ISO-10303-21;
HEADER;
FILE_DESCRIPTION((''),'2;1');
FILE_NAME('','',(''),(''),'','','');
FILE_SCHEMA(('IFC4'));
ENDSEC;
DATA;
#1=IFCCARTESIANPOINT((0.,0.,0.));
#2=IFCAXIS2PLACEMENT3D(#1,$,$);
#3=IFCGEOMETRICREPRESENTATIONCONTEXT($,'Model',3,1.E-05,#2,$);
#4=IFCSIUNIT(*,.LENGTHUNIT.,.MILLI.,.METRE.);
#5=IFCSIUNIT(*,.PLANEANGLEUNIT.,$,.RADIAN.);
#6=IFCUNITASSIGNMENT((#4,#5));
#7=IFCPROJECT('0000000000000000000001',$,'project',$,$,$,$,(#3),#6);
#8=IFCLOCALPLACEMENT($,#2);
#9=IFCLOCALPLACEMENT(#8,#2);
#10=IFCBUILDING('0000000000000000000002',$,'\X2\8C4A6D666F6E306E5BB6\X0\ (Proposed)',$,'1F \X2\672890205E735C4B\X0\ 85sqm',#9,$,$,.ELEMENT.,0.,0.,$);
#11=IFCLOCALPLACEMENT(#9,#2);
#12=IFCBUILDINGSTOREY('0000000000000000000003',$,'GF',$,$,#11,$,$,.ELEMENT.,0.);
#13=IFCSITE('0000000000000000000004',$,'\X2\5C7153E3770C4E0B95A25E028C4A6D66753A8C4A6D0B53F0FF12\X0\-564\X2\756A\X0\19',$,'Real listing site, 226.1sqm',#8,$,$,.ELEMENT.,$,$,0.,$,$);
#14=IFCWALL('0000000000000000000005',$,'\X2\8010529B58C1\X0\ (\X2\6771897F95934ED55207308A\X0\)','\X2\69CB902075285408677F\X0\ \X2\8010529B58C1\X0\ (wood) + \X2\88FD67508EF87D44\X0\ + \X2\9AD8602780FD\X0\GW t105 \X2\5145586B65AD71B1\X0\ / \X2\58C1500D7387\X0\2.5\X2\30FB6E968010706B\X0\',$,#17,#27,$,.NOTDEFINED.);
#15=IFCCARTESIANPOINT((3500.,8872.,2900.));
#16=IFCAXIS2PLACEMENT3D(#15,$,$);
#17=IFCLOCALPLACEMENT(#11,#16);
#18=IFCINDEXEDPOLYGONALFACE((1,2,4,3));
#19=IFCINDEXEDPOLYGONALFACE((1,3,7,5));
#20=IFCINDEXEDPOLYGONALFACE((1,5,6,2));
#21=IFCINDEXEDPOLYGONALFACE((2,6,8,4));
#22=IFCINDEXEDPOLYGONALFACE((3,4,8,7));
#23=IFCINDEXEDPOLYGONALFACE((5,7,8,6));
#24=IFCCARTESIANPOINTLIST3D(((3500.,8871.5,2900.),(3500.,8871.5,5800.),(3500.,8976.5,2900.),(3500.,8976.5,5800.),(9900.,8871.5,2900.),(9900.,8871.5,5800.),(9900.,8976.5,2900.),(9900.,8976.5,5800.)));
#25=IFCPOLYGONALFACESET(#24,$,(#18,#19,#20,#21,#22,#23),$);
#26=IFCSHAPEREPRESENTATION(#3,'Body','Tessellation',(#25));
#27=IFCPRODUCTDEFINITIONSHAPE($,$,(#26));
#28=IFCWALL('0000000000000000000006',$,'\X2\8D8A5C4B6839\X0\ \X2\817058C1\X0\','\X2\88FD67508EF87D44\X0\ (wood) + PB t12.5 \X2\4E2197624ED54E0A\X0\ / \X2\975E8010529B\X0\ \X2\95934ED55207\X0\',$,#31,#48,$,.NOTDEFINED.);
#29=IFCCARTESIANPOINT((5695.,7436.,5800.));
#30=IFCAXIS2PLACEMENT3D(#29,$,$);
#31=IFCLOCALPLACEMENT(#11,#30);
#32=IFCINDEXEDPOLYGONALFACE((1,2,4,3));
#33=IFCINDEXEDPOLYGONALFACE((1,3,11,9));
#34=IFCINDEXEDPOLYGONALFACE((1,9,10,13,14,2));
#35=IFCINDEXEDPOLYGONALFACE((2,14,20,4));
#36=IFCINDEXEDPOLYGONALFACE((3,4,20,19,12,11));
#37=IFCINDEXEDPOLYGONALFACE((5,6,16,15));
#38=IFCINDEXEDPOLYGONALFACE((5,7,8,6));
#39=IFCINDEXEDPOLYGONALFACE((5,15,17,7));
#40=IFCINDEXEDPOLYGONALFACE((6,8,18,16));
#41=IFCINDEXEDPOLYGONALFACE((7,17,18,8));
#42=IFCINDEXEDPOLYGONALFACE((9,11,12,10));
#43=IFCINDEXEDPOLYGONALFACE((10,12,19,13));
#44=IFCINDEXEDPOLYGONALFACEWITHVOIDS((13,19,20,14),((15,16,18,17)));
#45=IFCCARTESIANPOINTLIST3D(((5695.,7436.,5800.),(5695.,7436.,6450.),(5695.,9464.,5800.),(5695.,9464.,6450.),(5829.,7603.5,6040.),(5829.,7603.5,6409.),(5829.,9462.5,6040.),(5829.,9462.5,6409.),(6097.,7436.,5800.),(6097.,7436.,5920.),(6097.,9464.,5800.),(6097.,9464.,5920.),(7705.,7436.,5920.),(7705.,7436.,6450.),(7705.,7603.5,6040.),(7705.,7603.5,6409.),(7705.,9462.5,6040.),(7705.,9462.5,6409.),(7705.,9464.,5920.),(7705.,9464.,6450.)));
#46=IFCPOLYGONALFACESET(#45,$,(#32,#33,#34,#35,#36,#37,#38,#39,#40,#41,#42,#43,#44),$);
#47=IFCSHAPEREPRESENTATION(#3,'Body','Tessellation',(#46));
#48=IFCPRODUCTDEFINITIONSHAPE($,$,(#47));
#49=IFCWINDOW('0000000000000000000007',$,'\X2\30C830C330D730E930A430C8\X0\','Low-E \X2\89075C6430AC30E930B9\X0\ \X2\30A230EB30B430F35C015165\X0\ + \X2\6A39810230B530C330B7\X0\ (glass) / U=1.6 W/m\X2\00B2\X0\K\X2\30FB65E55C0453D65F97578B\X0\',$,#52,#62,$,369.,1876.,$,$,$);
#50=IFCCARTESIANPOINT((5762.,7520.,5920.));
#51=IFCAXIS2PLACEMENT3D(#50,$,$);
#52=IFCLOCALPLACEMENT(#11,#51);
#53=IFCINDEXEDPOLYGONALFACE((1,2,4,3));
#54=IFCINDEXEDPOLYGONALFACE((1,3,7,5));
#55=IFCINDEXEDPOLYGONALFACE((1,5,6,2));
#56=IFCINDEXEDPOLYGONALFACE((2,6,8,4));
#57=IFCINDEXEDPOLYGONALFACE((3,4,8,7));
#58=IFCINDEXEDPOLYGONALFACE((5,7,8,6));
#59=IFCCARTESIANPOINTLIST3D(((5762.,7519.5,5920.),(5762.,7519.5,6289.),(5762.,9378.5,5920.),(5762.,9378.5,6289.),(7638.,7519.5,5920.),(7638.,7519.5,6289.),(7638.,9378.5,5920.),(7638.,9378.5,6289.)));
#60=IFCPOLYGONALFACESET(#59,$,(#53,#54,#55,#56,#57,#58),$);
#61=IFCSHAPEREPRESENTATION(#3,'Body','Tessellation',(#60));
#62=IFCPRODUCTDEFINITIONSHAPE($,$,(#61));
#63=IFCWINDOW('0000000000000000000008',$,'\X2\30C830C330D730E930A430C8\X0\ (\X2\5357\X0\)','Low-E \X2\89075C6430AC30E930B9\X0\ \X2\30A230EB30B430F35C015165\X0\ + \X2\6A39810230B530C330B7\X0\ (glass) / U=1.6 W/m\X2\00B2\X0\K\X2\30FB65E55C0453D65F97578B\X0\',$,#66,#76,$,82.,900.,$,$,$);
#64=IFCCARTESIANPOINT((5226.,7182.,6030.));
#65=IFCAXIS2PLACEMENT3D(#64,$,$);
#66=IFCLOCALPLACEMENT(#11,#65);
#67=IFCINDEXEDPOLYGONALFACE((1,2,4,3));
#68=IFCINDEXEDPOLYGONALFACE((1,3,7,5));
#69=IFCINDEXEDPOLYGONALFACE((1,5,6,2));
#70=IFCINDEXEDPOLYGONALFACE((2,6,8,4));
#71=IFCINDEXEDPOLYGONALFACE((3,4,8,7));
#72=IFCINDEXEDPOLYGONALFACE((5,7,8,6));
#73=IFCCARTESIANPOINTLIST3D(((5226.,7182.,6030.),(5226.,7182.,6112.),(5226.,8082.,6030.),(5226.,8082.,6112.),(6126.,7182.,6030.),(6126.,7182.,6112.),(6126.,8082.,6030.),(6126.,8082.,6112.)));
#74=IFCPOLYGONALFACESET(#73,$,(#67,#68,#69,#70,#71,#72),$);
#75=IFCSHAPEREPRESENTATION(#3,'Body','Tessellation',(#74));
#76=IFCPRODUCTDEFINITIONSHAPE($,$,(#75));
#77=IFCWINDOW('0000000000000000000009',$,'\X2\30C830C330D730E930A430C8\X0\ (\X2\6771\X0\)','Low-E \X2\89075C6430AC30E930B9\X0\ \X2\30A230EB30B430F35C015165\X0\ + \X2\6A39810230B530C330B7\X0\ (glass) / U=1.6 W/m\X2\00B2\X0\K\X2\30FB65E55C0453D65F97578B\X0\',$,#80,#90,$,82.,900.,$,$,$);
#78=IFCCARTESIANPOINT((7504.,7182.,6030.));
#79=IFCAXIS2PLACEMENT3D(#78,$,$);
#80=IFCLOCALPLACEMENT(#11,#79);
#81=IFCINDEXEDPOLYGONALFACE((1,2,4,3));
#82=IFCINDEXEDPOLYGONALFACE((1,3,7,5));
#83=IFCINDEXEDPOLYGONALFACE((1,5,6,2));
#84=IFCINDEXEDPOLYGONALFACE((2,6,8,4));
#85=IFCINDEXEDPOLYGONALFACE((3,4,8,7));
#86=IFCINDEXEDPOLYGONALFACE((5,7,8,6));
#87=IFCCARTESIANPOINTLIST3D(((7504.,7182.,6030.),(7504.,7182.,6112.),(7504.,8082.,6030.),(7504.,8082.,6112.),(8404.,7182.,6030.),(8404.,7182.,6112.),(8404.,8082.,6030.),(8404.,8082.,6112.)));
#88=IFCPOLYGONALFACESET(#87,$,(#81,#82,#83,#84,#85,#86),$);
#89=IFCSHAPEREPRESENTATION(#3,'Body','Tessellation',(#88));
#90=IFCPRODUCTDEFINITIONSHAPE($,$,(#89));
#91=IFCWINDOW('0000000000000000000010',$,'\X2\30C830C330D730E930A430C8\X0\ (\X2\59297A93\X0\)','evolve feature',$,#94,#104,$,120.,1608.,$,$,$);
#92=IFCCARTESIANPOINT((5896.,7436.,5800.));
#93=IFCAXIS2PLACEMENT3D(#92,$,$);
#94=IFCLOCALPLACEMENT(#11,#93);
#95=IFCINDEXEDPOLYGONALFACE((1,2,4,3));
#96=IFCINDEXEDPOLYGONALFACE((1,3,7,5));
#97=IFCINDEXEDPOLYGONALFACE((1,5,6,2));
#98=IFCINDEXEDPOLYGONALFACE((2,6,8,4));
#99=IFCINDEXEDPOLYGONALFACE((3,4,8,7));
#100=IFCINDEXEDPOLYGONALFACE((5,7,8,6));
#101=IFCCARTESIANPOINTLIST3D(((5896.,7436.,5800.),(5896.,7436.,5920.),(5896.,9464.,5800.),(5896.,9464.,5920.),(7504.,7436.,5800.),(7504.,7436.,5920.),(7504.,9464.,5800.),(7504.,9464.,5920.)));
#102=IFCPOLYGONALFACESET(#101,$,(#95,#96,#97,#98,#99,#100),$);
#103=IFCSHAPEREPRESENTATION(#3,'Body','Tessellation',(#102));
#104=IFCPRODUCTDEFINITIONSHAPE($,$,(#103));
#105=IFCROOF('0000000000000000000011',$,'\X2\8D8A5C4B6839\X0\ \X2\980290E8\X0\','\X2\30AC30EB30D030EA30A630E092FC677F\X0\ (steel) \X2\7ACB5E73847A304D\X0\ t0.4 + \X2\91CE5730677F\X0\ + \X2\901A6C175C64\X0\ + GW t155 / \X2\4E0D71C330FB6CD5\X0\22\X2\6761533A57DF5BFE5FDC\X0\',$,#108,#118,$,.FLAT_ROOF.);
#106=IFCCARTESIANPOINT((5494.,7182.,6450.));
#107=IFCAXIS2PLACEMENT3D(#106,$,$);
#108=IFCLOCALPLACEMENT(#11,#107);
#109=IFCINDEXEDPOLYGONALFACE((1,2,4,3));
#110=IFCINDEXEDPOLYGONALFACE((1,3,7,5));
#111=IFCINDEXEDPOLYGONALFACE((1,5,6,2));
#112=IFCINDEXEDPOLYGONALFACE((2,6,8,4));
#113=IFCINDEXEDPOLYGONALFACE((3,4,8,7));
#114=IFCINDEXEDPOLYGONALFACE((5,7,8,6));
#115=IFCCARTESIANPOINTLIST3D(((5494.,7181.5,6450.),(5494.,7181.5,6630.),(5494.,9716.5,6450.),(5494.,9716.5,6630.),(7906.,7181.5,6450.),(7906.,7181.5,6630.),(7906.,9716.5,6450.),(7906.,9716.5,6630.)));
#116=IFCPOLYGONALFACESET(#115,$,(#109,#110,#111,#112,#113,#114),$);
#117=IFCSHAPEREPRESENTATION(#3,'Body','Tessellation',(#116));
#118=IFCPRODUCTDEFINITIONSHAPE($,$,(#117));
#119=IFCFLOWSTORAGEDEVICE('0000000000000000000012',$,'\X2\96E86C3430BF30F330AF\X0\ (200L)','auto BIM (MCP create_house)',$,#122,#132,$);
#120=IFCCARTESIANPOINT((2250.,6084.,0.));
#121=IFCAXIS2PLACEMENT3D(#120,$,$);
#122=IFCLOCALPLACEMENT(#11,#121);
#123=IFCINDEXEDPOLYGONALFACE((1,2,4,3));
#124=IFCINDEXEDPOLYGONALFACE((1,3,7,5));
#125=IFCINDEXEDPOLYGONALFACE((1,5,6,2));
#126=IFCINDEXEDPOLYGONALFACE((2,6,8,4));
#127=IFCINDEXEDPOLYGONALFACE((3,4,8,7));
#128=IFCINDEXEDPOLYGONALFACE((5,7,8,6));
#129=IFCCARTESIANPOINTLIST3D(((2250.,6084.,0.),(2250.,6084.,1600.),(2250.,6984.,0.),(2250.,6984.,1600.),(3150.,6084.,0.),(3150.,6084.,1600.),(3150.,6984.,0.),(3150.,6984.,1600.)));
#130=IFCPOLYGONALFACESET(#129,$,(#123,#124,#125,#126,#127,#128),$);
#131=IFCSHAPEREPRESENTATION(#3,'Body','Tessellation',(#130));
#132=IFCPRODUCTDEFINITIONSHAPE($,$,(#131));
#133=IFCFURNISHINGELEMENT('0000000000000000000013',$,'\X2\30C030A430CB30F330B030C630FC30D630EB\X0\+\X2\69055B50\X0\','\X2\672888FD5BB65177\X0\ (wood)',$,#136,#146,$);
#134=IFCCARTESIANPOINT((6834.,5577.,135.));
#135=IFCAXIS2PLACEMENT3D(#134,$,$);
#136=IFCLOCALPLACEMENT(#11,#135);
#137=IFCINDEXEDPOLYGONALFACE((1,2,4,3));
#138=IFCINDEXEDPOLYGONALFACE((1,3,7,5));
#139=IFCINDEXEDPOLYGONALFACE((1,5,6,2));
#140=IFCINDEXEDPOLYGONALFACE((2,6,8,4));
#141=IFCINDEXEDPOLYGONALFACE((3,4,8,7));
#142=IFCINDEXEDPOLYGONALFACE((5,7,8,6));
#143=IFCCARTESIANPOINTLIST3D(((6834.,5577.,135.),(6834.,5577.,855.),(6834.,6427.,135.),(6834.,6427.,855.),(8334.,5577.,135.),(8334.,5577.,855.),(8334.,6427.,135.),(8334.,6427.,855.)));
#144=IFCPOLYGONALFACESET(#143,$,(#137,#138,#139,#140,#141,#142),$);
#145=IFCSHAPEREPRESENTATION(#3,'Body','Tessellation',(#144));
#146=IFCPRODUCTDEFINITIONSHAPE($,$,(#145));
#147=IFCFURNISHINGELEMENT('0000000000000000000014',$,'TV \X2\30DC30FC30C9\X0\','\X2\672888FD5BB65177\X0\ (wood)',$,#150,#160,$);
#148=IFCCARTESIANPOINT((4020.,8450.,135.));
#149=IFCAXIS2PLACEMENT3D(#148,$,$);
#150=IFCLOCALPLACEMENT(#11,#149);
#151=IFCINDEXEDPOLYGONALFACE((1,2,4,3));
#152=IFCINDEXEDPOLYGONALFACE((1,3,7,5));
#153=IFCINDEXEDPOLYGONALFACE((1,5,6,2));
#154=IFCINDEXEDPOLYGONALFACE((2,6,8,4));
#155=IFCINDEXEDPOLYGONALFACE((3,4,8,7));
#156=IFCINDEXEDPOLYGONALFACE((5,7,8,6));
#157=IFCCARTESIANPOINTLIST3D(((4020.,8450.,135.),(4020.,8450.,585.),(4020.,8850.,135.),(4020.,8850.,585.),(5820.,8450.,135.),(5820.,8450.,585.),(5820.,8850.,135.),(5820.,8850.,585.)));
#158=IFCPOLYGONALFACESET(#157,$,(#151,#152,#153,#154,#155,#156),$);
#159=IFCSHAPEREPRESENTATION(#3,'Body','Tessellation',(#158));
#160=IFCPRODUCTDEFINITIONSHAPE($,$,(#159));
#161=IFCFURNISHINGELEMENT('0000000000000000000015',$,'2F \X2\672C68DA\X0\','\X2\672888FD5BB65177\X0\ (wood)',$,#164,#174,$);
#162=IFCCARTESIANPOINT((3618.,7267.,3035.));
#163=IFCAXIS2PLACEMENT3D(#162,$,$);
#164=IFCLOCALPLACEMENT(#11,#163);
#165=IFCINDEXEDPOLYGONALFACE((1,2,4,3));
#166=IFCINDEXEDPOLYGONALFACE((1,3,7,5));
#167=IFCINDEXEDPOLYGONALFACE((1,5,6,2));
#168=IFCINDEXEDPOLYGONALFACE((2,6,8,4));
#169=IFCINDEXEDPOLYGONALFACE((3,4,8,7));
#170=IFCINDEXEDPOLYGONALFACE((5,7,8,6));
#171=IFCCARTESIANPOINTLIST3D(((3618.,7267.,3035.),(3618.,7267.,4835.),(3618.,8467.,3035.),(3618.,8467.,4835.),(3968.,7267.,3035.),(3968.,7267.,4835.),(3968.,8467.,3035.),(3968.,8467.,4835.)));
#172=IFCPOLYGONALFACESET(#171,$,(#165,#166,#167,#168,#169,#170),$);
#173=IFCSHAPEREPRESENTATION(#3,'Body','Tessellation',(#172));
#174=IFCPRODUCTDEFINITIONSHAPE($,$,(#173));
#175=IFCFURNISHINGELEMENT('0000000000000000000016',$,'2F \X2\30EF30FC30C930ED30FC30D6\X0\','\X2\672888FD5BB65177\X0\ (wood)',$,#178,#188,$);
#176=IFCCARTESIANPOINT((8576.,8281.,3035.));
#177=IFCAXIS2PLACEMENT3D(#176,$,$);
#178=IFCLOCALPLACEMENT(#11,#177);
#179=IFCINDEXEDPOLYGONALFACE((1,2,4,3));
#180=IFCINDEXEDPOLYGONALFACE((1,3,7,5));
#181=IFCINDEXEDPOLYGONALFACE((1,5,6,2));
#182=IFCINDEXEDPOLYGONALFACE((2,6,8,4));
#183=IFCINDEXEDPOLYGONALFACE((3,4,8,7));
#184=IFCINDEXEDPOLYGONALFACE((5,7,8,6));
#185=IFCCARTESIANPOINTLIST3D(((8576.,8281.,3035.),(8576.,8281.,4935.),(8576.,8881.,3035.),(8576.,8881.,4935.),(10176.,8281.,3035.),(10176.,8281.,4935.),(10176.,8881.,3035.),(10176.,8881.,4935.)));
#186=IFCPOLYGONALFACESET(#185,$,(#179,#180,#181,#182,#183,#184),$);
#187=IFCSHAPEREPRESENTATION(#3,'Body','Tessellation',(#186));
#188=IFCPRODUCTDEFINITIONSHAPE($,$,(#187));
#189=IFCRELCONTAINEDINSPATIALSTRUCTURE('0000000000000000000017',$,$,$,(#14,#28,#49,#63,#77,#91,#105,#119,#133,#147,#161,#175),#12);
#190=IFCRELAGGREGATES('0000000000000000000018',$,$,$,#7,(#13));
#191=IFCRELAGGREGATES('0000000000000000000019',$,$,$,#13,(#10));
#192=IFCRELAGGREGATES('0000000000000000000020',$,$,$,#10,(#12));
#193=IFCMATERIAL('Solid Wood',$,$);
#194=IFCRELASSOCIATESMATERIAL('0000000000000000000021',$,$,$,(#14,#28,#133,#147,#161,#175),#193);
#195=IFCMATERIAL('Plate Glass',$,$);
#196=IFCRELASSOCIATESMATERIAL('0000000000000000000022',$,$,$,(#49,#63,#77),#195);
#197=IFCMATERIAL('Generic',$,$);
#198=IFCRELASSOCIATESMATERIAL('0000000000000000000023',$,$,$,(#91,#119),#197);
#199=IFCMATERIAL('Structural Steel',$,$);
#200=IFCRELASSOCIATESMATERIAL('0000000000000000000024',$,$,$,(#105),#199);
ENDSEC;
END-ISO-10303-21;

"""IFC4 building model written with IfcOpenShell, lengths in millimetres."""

from ifc_helpers import new_model, si_unit, frame, frame_2d, origin, place, context, project, spatial, rectangle, extrude, material, element, fill, save


model = new_model("IFC4")

# Units and contexts
model_context = context("Model", 3, precision=1e-05, world=origin())
ifc_project = project(units=[si_unit("LENGTHUNIT", "METRE", prefix="MILLI"), si_unit("PLANEANGLEUNIT", "RADIAN")], contexts=[model_context])

# Site, building, storey
site_placement = place(None, origin())
site = spatial("IfcSite", under=ifc_project, at=site_placement, Name="山口県下関市豊浦町豊洋台２-564番19", ObjectType="Real listing site, 226.1sqm", CompositionType="ELEMENT", RefElevation=0.0)
building_placement = place(site_placement, origin())
building = spatial("IfcBuilding", under=site, at=building_placement, Name="豊浦潮の家 (Proposed)", ObjectType="1F 木造平屋 85sqm", CompositionType="ELEMENT", ElevationOfRefHeight=0.0, ElevationOfTerrain=0.0)
storey_placement = place(building_placement, origin())
storey = spatial("IfcBuildingStorey", under=building, at=storey_placement, Name="GF", CompositionType="ELEMENT", Elevation=0.0)

# Wall
ifc_material_1 = material(Name="Solid Wood")
wall_1_placement = place(storey_placement, frame((3500.0, 8872.0, 2900.0)))
element("IfcWall", 1, at=wall_1_placement, inside=storey, material=ifc_material_1, Name="耐力壁 (東西間仕切り)", Description="構造用合板 耐力壁 (wood) + 製材軸組 + 高性能GW t105 充填断熱 / 壁倍率2.5・準耐火", PredefinedType="NOTDEFINED", context=model_context, shape_type="SweptSolid", body=[
    extrude(rectangle(XDim=6400.0, YDim=105.0, at=frame_2d((3200.0, 52.0))), frame((3500.0, 8872.0, 2900.0)), (0.0, 0.0, 1.0), 2900.0),
])

# Wall, openings, windows
wall_2_placement = place(storey_placement, frame((5695.0, 7436.0, 5800.0)))
wall_2 = element("IfcWall", 2, at=wall_2_placement, inside=storey, material=ifc_material_1, Name="越屋根 腰壁", Description="製材軸組 (wood) + PB t12.5 両面仕上 / 非耐力 間仕切", PredefinedType="NOTDEFINED", context=model_context, shape_type="SweptSolid", body=[
    extrude(rectangle(XDim=2010.0, YDim=2028.0, at=frame_2d((1005.0, 1014.0))), frame((5695.0, 7436.0, 5800.0)), (0.0, 0.0, 1.0), 650.0),
])
opening_1_placement = place(storey_placement, frame((5762.0, 7520.0, 5920.0)))
opening_1 = element("IfcOpeningElement", 3, at=opening_1_placement, cuts=wall_2, PredefinedType="NOTDEFINED", context=model_context, shape_type="SweptSolid", body=[
    extrude(rectangle(XDim=1876.0, YDim=1859.0, at=frame_2d((938.0, 929.0))), frame((5762.0, 7520.0, 5920.0)), (0.0, 0.0, 1.0), 369.0),
])
opening_2_placement = place(storey_placement, frame((5226.0, 7182.0, 6030.0)))
opening_2 = element("IfcOpeningElement", 4, at=opening_2_placement, cuts=wall_2, PredefinedType="NOTDEFINED", context=model_context, shape_type="SweptSolid", body=[
    extrude(rectangle(XDim=900.0, YDim=900.0, at=frame_2d((450.0, 450.0))), frame((5226.0, 7182.0, 6030.0)), (0.0, 0.0, 1.0), 82.0),
])
opening_3_placement = place(storey_placement, frame((7504.0, 7182.0, 6030.0)))
opening_3 = element("IfcOpeningElement", 5, at=opening_3_placement, cuts=wall_2, PredefinedType="NOTDEFINED", context=model_context, shape_type="SweptSolid", body=[
    extrude(rectangle(XDim=900.0, YDim=900.0, at=frame_2d((450.0, 450.0))), frame((7504.0, 7182.0, 6030.0)), (0.0, 0.0, 1.0), 82.0),
])
opening_4_placement = place(storey_placement, frame((5896.0, 7436.0, 5800.0)))
opening_4 = element("IfcOpeningElement", 6, at=opening_4_placement, cuts=wall_2, PredefinedType="NOTDEFINED", context=model_context, shape_type="SweptSolid", body=[
    extrude(rectangle(XDim=1608.0, YDim=2028.0, at=frame_2d((804.0, 1014.0))), frame((5896.0, 7436.0, 5800.0)), (0.0, 0.0, 1.0), 120.0),
])
ifc_material_2 = material(Name="Plate Glass")
window_1_placement = place(storey_placement, frame((5762.0, 7520.0, 5920.0)))
window_1 = element("IfcWindow", 7, at=window_1_placement, inside=storey, material=ifc_material_2, Name="トップライト", Description="Low-E 複層ガラス アルゴン封入 + 樹脂サッシ (glass) / U=1.6 W/m²K・日射取得型", OverallHeight=369.0, OverallWidth=1876.0, context=model_context, shape_type="SweptSolid", body=[
    extrude(rectangle(XDim=1876.0, YDim=1859.0, at=frame_2d((938.0, 929.0))), frame((5762.0, 7520.0, 5920.0)), (0.0, 0.0, 1.0), 369.0),
])
fill(opening_1, window_1)
window_2_placement = place(storey_placement, frame((5226.0, 7182.0, 6030.0)))
window_2 = element("IfcWindow", 8, at=window_2_placement, inside=storey, material=ifc_material_2, Name="トップライト (南)", Description="Low-E 複層ガラス アルゴン封入 + 樹脂サッシ (glass) / U=1.6 W/m²K・日射取得型", OverallHeight=82.0, OverallWidth=900.0, context=model_context, shape_type="SweptSolid", body=[
    extrude(rectangle(XDim=900.0, YDim=900.0, at=frame_2d((450.0, 450.0))), frame((5226.0, 7182.0, 6030.0)), (0.0, 0.0, 1.0), 82.0),
])
fill(opening_2, window_2)
window_3_placement = place(storey_placement, frame((7504.0, 7182.0, 6030.0)))
window_3 = element("IfcWindow", 9, at=window_3_placement, inside=storey, material=ifc_material_2, Name="トップライト (東)", Description="Low-E 複層ガラス アルゴン封入 + 樹脂サッシ (glass) / U=1.6 W/m²K・日射取得型", OverallHeight=82.0, OverallWidth=900.0, context=model_context, shape_type="SweptSolid", body=[
    extrude(rectangle(XDim=900.0, YDim=900.0, at=frame_2d((450.0, 450.0))), frame((7504.0, 7182.0, 6030.0)), (0.0, 0.0, 1.0), 82.0),
])
fill(opening_3, window_3)
ifc_material_3 = material(Name="Generic")
window_4_placement = place(storey_placement, frame((5896.0, 7436.0, 5800.0)))
window_4 = element("IfcWindow", 10, at=window_4_placement, inside=storey, material=ifc_material_3, Name="トップライト (天窓)", Description="evolve feature", OverallHeight=120.0, OverallWidth=1608.0, context=model_context, shape_type="SweptSolid", body=[
    extrude(rectangle(XDim=1608.0, YDim=2028.0, at=frame_2d((804.0, 1014.0))), frame((5896.0, 7436.0, 5800.0)), (0.0, 0.0, 1.0), 120.0),
])
fill(opening_4, window_4)

# Roof
ifc_material_4 = material(Name="Structural Steel")
roof_placement = place(storey_placement, frame((5494.0, 7182.0, 6450.0)))
element("IfcRoof", 11, at=roof_placement, inside=storey, material=ifc_material_4, Name="越屋根 頂部", Description="ガルバリウム鋼板 (steel) 立平葺き t0.4 + 野地板 + 通気層 + GW t155 / 不燃・法22条区域対応", PredefinedType="FLAT_ROOF", context=model_context, shape_type="SweptSolid", body=[
    extrude(rectangle(XDim=2412.0, YDim=2535.0, at=frame_2d((1206.0, 1267.0))), frame((5494.0, 7182.0, 6450.0)), (0.0, 0.0, 1.0), 180.0),
])

# Flow storage device
flow_storage_device_placement = place(storey_placement, frame((2250.0, 6084.0, 0.0)))
element("IfcFlowStorageDevice", 12, at=flow_storage_device_placement, inside=storey, material=ifc_material_3, Name="雨水タンク (200L)", Description="auto BIM (MCP create_house)", context=model_context, shape_type="SweptSolid", body=[
    extrude(rectangle(XDim=900.0, YDim=900.0, at=frame_2d((450.0, 450.0))), frame((2250.0, 6084.0, 0.0)), (0.0, 0.0, 1.0), 1600.0),
])

# Furnishing elements
furnishing_1_placement = place(storey_placement, frame((6834.0, 5577.0, 135.0)))
element("IfcFurnishingElement", 13, at=furnishing_1_placement, inside=storey, material=ifc_material_1, Name="ダイニングテーブル+椅子", Description="木製家具 (wood)", context=model_context, shape_type="SweptSolid", body=[
    extrude(rectangle(XDim=1500.0, YDim=850.0, at=frame_2d((750.0, 425.0))), frame((6834.0, 5577.0, 135.0)), (0.0, 0.0, 1.0), 720.0),
])
furnishing_2_placement = place(storey_placement, frame((4020.0, 8450.0, 135.0)))
element("IfcFurnishingElement", 14, at=furnishing_2_placement, inside=storey, material=ifc_material_1, Name="TV ボード", Description="木製家具 (wood)", context=model_context, shape_type="SweptSolid", body=[
    extrude(rectangle(XDim=1800.0, YDim=400.0, at=frame_2d((900.0, 200.0))), frame((4020.0, 8450.0, 135.0)), (0.0, 0.0, 1.0), 450.0),
])
furnishing_3_placement = place(storey_placement, frame((3618.0, 7267.0, 3035.0)))
element("IfcFurnishingElement", 15, at=furnishing_3_placement, inside=storey, material=ifc_material_1, Name="2F 本棚", Description="木製家具 (wood)", context=model_context, shape_type="SweptSolid", body=[
    extrude(rectangle(XDim=350.0, YDim=1200.0, at=frame_2d((175.0, 600.0))), frame((3618.0, 7267.0, 3035.0)), (0.0, 0.0, 1.0), 1800.0),
])
furnishing_4_placement = place(storey_placement, frame((8576.0, 8281.0, 3035.0)))
element("IfcFurnishingElement", 16, at=furnishing_4_placement, inside=storey, material=ifc_material_1, Name="2F ワードローブ", Description="木製家具 (wood)", context=model_context, shape_type="SweptSolid", body=[
    extrude(rectangle(XDim=1600.0, YDim=600.0, at=frame_2d((800.0, 300.0))), frame((8576.0, 8281.0, 3035.0)), (0.0, 0.0, 1.0), 1900.0),
])

save(model, "model.ifc")
